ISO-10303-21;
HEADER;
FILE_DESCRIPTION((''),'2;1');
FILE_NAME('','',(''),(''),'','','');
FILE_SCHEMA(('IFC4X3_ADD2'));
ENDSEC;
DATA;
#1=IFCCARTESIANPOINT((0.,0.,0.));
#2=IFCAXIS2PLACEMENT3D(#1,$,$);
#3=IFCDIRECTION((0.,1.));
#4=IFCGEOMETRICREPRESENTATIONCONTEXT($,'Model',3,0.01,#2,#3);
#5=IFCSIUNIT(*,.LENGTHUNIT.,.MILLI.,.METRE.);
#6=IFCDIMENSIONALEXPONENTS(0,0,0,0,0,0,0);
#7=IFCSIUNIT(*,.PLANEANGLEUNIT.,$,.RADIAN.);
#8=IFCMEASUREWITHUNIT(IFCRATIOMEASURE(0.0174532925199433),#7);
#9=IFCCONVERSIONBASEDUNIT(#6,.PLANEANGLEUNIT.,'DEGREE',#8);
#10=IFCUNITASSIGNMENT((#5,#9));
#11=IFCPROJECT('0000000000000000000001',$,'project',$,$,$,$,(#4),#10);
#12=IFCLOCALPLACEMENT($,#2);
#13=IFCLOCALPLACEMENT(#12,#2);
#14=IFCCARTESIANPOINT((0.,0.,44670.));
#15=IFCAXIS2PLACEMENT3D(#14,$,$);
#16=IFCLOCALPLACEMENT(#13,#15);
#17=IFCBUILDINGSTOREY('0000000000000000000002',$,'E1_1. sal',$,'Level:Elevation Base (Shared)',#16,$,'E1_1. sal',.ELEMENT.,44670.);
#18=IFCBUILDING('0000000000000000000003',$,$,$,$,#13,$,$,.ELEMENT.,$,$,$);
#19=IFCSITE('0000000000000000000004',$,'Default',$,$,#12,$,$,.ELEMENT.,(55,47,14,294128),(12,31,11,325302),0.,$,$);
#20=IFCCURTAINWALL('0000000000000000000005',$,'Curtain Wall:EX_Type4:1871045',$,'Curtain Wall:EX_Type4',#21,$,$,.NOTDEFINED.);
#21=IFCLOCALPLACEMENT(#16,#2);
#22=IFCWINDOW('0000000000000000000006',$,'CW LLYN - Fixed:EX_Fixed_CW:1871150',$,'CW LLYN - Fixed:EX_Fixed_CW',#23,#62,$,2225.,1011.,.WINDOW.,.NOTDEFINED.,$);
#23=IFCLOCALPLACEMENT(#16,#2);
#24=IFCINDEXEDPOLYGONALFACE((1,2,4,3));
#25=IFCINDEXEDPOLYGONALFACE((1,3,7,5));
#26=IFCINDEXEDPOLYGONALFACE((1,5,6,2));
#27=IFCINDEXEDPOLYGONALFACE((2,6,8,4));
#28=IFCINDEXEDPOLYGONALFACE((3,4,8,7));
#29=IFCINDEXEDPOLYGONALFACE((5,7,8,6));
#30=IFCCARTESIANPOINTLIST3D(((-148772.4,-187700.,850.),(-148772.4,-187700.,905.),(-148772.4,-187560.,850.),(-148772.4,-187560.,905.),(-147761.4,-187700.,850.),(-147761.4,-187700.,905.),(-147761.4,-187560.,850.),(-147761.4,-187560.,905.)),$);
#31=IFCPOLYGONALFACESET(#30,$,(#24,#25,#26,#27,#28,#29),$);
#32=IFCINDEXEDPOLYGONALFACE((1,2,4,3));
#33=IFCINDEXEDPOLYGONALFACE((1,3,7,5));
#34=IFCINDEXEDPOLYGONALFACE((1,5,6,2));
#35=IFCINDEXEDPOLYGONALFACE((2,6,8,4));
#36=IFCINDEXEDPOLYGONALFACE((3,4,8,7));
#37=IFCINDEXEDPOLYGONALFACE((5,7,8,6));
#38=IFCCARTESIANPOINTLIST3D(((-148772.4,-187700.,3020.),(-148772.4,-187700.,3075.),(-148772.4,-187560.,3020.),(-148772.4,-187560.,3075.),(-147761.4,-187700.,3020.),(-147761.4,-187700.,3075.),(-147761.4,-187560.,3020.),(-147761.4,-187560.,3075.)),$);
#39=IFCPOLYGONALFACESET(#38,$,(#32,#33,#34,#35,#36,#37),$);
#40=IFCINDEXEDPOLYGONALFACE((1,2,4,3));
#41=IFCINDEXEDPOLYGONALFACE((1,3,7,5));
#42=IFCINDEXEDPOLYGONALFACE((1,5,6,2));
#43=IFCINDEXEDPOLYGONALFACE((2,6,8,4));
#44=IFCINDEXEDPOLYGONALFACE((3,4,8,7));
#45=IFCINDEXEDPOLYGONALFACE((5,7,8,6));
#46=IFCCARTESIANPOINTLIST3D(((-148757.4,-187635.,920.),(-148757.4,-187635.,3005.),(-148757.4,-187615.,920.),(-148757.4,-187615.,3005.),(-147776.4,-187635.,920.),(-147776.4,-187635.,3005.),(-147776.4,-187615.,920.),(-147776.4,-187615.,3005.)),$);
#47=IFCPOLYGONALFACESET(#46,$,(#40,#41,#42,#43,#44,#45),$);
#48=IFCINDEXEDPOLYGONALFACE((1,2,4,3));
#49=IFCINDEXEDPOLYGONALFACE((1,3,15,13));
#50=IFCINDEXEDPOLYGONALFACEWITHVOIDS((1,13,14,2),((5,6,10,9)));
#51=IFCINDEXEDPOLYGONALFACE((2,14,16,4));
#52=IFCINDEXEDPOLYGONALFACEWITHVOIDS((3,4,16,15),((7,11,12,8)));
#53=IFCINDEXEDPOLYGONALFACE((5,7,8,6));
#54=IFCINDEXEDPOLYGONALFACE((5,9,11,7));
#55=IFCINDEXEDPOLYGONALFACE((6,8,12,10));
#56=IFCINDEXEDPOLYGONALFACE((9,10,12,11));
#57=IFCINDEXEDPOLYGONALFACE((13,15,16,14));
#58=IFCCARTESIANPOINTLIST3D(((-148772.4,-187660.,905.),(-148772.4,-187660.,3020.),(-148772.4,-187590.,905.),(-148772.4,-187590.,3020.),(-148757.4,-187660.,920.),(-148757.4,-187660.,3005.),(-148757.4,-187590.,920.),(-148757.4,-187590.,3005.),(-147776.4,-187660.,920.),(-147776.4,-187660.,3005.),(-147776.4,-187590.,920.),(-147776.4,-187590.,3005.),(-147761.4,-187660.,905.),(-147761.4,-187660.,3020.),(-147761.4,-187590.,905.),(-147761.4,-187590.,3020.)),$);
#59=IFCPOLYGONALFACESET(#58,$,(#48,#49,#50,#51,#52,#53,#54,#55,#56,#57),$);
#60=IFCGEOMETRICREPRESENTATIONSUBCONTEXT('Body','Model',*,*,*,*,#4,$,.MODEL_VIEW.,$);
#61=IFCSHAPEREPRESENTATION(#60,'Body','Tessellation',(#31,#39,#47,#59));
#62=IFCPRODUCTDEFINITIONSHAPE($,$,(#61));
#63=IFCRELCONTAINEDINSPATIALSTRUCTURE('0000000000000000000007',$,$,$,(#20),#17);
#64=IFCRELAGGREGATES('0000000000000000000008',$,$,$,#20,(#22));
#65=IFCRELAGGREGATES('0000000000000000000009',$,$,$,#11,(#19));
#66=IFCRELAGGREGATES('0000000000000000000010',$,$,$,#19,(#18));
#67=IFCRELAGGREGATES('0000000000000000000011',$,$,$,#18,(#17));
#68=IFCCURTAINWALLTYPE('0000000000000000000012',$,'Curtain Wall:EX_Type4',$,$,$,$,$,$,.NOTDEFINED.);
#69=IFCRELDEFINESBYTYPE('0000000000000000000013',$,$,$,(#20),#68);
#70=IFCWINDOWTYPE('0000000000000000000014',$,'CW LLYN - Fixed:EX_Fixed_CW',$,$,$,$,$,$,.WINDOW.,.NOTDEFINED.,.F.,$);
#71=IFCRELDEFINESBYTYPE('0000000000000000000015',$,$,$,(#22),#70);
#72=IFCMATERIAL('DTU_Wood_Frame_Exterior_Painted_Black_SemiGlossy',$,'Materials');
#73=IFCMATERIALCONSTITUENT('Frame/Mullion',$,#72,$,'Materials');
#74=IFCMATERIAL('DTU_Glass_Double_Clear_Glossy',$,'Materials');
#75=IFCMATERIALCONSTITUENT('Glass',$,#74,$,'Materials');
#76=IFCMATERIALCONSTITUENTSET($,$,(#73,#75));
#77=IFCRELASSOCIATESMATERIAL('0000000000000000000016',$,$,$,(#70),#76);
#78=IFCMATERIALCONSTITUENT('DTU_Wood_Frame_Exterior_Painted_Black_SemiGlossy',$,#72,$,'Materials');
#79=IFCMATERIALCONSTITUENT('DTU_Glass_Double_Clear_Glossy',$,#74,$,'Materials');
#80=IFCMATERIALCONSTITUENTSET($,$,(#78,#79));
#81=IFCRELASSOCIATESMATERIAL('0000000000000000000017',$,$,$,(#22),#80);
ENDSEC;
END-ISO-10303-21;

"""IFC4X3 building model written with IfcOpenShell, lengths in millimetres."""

from ifc_helpers import new_model, entity, si_unit, converted_unit, direction, frame, frame_2d, origin, origin_2d_with_axis, place, context, subcontext, project, spatial, polyline, rectangle, outline, extrude, source, transform, mapped, material, constituent, constituent_set, type_object, type_shapes, element, aggregate, save


model = new_model("IFC4X3")

# Units and contexts
model_context = context("Model", 3, precision=0.01, world=origin(), true_north=direction((0.0, 1.0)))
body_context = subcontext(model_context, "Body", "Model", "MODEL_VIEW")
ifc_project = project(units=[si_unit("LENGTHUNIT", "METRE", prefix="MILLI"), converted_unit("PLANEANGLEUNIT", "DEGREE", entity("IfcRatioMeasure", 0.0174532925199433), si_unit("PLANEANGLEUNIT", "RADIAN"), dimensions=[0, 0, 0, 0, 0, 0, 0])], contexts=[model_context])

# Site, building, storey
site_placement = place(None, origin())
site = spatial("IfcSite", under=ifc_project, at=site_placement, Name="Default", CompositionType="ELEMENT", RefLatitude=(55, 47, 14, 294128), RefLongitude=(12, 31, 11, 325302), RefElevation=0.0)
building_placement = place(site_placement, origin())
building = spatial("IfcBuilding", under=site, at=building_placement, CompositionType="ELEMENT")
storey_placement = place(building_placement, frame((0.0, 0.0, 44670.0)))
storey = spatial("IfcBuildingStorey", under=building, at=storey_placement, Name="E1_1. sal", ObjectType="Level:Elevation Base (Shared)", LongName="E1_1. sal", CompositionType="ELEMENT", Elevation=44670.0)

# Curtain wall, window
curtain_wall_type = type_object("IfcCurtainWallType", Name="Curtain Wall:EX_Type4", PredefinedType="NOTDEFINED")
curtain_wall_placement = place(storey_placement, frame((0.0, 0.0, -44670.0)))
curtain_wall = element("IfcCurtainWall", 1, at=curtain_wall_placement, inside=storey, type_object=curtain_wall_type, Name="Curtain Wall:EX_Type4:1871045", ObjectType="Curtain Wall:EX_Type4", PredefinedType="NOTDEFINED")
ifc_material_1 = material(Name="DTU_Wood_Frame_Exterior_Painted_Black_SemiGlossy", Category="Materials")
ifc_material_2 = material(Name="DTU_Glass_Double_Clear_Glossy", Category="Materials")
ifc_constituent_1 = constituent(ifc_material_1, Name="DTU_Wood_Frame_Exterior_Painted_Black_SemiGlossy", Category="Materials")
ifc_constituent_2 = constituent(ifc_material_2, Name="DTU_Glass_Double_Clear_Glossy", Category="Materials")
ifc_constituent_set_1 = constituent_set(constituents=[ifc_constituent_1, ifc_constituent_2])
ifc_constituent_3 = constituent(ifc_material_1, Name="Frame/Mullion", Category="Materials")
ifc_constituent_4 = constituent(ifc_material_2, Name="Glass", Category="Materials")
ifc_constituent_set_2 = constituent_set(constituents=[ifc_constituent_3, ifc_constituent_4])
window_type_1 = type_object("IfcWindowType", Name="CW LLYN - Fixed:EX_Fixed_CW", ParameterTakesPrecedence=False, PartitioningType="NOTDEFINED", PredefinedType="WINDOW", material=ifc_constituent_set_2)
shared_shape_1 = source(origin(), body_context, "Body", "SweptSolid", [
    extrude(rectangle(XDim=140.0, YDim=1011.0, at=origin_2d_with_axis()), frame((0.0, -130.0, 0.0), z_axis=(0.0, 0.0, 1.0), x_axis=(0.0, -1.0, 0.0)), (0.0, 0.0, 1.0), 55.0),
    extrude(rectangle(XDim=140.0, YDim=1011.0, at=frame_2d((0.0, 0.0), x_axis=(1.0, 0.0))), frame((0.0, -130.0, 2170.0), z_axis=(0.0, 0.0, 1.0), x_axis=(0.0, -1.0, 0.0)), (0.0, 0.0, 1.0), 55.0),
    extrude(rectangle(XDim=981.0, YDim=20.0, at=origin_2d_with_axis()), frame((0.0, -125.0, 70.0), z_axis=(0.0, 0.0, 1.0), x_axis=(-1.0, 0.0, 0.0)), (0.0, 0.0, 1.0), 2085.0),
    extrude(outline(polyline([(-1057.5, -505.5), (1057.5, -505.5), (1057.5, 505.5), (-1057.5, 505.5), (-1057.5, -505.5)]), holes=[polyline([(-1042.5, 490.5), (1042.5, 490.5), (1042.5, -490.5), (-1042.5, -490.5), (-1042.5, 490.5)])]), frame((0.0, -90.0, 1112.5), z_axis=(0.0, -1.0, 0.0), x_axis=(0.0, 0.0, 1.0)), (0.0, 0.0, 1.0), 70.0),
])
type_shapes(window_type_1, [shared_shape_1])
window_1_placement = place(curtain_wall_placement, frame((-148266.9, -187500.0, 45520.0)))
window_1 = element("IfcWindow", 2, at=window_1_placement, type_object=window_type_1, material=ifc_constituent_set_1, Name="CW LLYN - Fixed:EX_Fixed_CW:1871150", ObjectType="CW LLYN - Fixed:EX_Fixed_CW", OverallHeight=2225.0, OverallWidth=1011.0, PartitioningType="NOTDEFINED", PredefinedType="WINDOW", context=body_context, shape_type="MappedRepresentation", body=[
    mapped(shared_shape_1, transform((0.0, 0.0, 0.0), scale=1.0)),
])
aggregate(curtain_wall, [window_1])

save(model, "model.ifc")
